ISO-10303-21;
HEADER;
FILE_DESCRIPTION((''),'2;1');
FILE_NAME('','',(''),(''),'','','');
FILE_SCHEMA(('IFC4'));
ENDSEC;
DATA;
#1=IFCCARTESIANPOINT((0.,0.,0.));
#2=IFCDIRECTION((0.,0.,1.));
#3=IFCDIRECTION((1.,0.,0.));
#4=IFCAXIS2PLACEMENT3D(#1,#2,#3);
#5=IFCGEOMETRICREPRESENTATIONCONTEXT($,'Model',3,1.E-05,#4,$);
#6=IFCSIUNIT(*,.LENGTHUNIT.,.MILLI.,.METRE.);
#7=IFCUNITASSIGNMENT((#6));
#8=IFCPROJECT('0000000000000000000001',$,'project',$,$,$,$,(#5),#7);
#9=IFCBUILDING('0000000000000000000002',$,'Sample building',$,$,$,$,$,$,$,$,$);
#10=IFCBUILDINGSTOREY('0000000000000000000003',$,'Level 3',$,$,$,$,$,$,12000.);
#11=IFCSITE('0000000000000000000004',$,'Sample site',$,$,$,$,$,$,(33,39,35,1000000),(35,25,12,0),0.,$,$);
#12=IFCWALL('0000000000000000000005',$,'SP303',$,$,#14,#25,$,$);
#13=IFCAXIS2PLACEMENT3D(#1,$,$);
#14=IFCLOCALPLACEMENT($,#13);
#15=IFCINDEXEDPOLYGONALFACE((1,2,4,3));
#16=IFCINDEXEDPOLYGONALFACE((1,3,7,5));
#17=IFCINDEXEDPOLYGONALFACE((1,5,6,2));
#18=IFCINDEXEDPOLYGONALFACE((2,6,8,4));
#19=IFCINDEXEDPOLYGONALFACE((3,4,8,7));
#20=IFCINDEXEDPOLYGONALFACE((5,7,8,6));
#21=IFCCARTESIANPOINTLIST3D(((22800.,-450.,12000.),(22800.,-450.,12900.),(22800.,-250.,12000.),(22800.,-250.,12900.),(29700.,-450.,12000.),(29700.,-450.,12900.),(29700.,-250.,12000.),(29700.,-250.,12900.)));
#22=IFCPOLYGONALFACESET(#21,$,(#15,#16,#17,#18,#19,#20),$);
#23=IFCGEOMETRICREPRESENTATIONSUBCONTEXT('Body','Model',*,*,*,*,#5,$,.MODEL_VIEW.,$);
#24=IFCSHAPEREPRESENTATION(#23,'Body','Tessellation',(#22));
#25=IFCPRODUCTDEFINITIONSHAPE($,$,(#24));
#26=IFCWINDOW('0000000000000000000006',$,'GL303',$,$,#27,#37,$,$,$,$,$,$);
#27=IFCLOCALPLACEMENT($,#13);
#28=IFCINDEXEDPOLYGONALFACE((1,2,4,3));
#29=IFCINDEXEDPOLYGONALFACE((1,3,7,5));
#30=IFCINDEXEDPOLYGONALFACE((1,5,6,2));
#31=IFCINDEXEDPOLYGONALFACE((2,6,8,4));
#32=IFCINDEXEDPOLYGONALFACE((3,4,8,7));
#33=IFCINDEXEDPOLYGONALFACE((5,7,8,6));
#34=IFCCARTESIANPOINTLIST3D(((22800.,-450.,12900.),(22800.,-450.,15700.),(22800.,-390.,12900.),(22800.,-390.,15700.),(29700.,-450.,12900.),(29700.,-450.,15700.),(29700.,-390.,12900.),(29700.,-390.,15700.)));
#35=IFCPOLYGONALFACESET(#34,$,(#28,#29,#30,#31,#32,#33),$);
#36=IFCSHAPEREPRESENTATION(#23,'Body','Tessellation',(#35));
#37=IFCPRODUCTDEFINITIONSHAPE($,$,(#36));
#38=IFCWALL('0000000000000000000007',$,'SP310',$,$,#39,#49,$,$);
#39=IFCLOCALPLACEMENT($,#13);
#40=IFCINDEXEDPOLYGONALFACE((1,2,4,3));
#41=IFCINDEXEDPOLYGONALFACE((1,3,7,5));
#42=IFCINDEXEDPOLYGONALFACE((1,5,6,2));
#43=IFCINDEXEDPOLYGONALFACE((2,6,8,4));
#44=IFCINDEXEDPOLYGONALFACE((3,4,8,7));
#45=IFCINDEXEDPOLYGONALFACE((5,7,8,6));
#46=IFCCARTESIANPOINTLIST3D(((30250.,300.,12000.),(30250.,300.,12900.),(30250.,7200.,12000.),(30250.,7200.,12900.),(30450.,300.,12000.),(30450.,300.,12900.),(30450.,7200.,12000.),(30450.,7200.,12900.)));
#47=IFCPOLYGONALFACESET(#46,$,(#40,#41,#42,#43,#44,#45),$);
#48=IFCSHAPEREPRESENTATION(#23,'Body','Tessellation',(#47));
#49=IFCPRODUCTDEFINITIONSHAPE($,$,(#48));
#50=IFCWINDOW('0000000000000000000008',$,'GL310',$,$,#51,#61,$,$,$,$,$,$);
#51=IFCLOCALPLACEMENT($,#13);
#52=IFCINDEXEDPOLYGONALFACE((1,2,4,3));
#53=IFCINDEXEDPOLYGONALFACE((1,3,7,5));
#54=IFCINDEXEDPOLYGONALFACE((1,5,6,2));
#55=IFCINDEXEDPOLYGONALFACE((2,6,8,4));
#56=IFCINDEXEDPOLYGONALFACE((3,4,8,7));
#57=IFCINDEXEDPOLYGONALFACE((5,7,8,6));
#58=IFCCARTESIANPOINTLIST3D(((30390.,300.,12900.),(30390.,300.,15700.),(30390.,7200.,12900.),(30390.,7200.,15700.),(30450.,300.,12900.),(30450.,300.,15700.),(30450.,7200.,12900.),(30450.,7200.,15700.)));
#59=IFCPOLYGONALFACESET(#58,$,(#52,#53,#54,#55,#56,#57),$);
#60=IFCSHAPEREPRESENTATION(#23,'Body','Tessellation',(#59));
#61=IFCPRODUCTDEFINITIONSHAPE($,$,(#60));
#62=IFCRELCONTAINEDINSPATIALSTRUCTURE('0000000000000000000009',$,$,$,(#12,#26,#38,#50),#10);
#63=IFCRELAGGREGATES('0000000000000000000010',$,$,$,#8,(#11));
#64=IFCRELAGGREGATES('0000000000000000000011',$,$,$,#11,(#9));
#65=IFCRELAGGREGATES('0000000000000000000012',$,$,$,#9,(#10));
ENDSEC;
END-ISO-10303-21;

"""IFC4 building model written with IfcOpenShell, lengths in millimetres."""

from ifc_helpers import new_model, si_unit, frame, origin_with_axes, place, context, subcontext, project, spatial, indexed_curve, outline, extrude, element, save


model = new_model("IFC4")

# Units and contexts
model_context = context("Model", 3, precision=1e-05, world=origin_with_axes())
body_context = subcontext(model_context, "Body", "Model", "MODEL_VIEW")
ifc_project = project(units=[si_unit("LENGTHUNIT", "METRE", prefix="MILLI")], contexts=[model_context])

# Site, building, storey
site = spatial("IfcSite", under=ifc_project, Name="Sample site", RefLatitude=(33, 39, 35, 1000000), RefLongitude=(35, 25, 12, 0), RefElevation=0.0)
building = spatial("IfcBuilding", under=site, Name="Sample building")
storey = spatial("IfcBuildingStorey", under=building, Name="Level 3", Elevation=12000.0)

# Wall
wall_1_placement = place(None, frame((22800.0, -450.0, 12000.0), z_axis=(0.0, 0.0, 1.0), x_axis=(1.0, 0.0, 0.0)))
element("IfcWall", 1, at=wall_1_placement, inside=storey, Name="SP303", context=body_context, shape_type="SweptSolid", body=[
    extrude(outline(indexed_curve([(0.0, 0.0), (0.0, 200.0), (6900.0, 200.0), (6900.0, 0.0), (0.0, 0.0)], self_intersect=False)), origin_with_axes(), (0.0, 0.0, 1.0), 900.0),
])

# Window
window_1_placement = place(None, frame((22800.0, -450.0, 12900.0), z_axis=(0.0, 0.0, 1.0), x_axis=(1.0, 0.0, 0.0)))
element("IfcWindow", 2, at=window_1_placement, inside=storey, Name="GL303", context=body_context, shape_type="SweptSolid", body=[
    extrude(outline(indexed_curve([(0.0, 0.0), (0.0, 60.0), (6900.0, 60.0), (6900.0, 0.0), (0.0, 0.0)], self_intersect=False)), origin_with_axes(), (0.0, 0.0, 1.0), 2800.0),
])

# Wall
wall_2_placement = place(None, frame((30450.0, 300.0, 12000.0), z_axis=(0.0, 0.0, 1.0), x_axis=(0.0, 1.0, 0.0)))
element("IfcWall", 3, at=wall_2_placement, inside=storey, Name="SP310", context=body_context, shape_type="SweptSolid", body=[
    extrude(outline(indexed_curve([(0.0, 0.0), (0.0, 200.0), (6900.0, 200.0), (6900.0, 0.0), (0.0, 0.0)], self_intersect=False)), origin_with_axes(), (0.0, 0.0, 1.0), 900.0),
])

# Window
window_2_placement = place(None, frame((30450.0, 300.0, 12900.0), z_axis=(0.0, 0.0, 1.0), x_axis=(0.0, 1.0, 0.0)))
element("IfcWindow", 4, at=window_2_placement, inside=storey, Name="GL310", context=body_context, shape_type="SweptSolid", body=[
    extrude(outline(indexed_curve([(0.0, 0.0), (0.0, 60.0), (6900.0, 60.0), (6900.0, 0.0), (0.0, 0.0)], self_intersect=False)), origin_with_axes(), (0.0, 0.0, 1.0), 2800.0),
])

save(model, "model.ifc")
